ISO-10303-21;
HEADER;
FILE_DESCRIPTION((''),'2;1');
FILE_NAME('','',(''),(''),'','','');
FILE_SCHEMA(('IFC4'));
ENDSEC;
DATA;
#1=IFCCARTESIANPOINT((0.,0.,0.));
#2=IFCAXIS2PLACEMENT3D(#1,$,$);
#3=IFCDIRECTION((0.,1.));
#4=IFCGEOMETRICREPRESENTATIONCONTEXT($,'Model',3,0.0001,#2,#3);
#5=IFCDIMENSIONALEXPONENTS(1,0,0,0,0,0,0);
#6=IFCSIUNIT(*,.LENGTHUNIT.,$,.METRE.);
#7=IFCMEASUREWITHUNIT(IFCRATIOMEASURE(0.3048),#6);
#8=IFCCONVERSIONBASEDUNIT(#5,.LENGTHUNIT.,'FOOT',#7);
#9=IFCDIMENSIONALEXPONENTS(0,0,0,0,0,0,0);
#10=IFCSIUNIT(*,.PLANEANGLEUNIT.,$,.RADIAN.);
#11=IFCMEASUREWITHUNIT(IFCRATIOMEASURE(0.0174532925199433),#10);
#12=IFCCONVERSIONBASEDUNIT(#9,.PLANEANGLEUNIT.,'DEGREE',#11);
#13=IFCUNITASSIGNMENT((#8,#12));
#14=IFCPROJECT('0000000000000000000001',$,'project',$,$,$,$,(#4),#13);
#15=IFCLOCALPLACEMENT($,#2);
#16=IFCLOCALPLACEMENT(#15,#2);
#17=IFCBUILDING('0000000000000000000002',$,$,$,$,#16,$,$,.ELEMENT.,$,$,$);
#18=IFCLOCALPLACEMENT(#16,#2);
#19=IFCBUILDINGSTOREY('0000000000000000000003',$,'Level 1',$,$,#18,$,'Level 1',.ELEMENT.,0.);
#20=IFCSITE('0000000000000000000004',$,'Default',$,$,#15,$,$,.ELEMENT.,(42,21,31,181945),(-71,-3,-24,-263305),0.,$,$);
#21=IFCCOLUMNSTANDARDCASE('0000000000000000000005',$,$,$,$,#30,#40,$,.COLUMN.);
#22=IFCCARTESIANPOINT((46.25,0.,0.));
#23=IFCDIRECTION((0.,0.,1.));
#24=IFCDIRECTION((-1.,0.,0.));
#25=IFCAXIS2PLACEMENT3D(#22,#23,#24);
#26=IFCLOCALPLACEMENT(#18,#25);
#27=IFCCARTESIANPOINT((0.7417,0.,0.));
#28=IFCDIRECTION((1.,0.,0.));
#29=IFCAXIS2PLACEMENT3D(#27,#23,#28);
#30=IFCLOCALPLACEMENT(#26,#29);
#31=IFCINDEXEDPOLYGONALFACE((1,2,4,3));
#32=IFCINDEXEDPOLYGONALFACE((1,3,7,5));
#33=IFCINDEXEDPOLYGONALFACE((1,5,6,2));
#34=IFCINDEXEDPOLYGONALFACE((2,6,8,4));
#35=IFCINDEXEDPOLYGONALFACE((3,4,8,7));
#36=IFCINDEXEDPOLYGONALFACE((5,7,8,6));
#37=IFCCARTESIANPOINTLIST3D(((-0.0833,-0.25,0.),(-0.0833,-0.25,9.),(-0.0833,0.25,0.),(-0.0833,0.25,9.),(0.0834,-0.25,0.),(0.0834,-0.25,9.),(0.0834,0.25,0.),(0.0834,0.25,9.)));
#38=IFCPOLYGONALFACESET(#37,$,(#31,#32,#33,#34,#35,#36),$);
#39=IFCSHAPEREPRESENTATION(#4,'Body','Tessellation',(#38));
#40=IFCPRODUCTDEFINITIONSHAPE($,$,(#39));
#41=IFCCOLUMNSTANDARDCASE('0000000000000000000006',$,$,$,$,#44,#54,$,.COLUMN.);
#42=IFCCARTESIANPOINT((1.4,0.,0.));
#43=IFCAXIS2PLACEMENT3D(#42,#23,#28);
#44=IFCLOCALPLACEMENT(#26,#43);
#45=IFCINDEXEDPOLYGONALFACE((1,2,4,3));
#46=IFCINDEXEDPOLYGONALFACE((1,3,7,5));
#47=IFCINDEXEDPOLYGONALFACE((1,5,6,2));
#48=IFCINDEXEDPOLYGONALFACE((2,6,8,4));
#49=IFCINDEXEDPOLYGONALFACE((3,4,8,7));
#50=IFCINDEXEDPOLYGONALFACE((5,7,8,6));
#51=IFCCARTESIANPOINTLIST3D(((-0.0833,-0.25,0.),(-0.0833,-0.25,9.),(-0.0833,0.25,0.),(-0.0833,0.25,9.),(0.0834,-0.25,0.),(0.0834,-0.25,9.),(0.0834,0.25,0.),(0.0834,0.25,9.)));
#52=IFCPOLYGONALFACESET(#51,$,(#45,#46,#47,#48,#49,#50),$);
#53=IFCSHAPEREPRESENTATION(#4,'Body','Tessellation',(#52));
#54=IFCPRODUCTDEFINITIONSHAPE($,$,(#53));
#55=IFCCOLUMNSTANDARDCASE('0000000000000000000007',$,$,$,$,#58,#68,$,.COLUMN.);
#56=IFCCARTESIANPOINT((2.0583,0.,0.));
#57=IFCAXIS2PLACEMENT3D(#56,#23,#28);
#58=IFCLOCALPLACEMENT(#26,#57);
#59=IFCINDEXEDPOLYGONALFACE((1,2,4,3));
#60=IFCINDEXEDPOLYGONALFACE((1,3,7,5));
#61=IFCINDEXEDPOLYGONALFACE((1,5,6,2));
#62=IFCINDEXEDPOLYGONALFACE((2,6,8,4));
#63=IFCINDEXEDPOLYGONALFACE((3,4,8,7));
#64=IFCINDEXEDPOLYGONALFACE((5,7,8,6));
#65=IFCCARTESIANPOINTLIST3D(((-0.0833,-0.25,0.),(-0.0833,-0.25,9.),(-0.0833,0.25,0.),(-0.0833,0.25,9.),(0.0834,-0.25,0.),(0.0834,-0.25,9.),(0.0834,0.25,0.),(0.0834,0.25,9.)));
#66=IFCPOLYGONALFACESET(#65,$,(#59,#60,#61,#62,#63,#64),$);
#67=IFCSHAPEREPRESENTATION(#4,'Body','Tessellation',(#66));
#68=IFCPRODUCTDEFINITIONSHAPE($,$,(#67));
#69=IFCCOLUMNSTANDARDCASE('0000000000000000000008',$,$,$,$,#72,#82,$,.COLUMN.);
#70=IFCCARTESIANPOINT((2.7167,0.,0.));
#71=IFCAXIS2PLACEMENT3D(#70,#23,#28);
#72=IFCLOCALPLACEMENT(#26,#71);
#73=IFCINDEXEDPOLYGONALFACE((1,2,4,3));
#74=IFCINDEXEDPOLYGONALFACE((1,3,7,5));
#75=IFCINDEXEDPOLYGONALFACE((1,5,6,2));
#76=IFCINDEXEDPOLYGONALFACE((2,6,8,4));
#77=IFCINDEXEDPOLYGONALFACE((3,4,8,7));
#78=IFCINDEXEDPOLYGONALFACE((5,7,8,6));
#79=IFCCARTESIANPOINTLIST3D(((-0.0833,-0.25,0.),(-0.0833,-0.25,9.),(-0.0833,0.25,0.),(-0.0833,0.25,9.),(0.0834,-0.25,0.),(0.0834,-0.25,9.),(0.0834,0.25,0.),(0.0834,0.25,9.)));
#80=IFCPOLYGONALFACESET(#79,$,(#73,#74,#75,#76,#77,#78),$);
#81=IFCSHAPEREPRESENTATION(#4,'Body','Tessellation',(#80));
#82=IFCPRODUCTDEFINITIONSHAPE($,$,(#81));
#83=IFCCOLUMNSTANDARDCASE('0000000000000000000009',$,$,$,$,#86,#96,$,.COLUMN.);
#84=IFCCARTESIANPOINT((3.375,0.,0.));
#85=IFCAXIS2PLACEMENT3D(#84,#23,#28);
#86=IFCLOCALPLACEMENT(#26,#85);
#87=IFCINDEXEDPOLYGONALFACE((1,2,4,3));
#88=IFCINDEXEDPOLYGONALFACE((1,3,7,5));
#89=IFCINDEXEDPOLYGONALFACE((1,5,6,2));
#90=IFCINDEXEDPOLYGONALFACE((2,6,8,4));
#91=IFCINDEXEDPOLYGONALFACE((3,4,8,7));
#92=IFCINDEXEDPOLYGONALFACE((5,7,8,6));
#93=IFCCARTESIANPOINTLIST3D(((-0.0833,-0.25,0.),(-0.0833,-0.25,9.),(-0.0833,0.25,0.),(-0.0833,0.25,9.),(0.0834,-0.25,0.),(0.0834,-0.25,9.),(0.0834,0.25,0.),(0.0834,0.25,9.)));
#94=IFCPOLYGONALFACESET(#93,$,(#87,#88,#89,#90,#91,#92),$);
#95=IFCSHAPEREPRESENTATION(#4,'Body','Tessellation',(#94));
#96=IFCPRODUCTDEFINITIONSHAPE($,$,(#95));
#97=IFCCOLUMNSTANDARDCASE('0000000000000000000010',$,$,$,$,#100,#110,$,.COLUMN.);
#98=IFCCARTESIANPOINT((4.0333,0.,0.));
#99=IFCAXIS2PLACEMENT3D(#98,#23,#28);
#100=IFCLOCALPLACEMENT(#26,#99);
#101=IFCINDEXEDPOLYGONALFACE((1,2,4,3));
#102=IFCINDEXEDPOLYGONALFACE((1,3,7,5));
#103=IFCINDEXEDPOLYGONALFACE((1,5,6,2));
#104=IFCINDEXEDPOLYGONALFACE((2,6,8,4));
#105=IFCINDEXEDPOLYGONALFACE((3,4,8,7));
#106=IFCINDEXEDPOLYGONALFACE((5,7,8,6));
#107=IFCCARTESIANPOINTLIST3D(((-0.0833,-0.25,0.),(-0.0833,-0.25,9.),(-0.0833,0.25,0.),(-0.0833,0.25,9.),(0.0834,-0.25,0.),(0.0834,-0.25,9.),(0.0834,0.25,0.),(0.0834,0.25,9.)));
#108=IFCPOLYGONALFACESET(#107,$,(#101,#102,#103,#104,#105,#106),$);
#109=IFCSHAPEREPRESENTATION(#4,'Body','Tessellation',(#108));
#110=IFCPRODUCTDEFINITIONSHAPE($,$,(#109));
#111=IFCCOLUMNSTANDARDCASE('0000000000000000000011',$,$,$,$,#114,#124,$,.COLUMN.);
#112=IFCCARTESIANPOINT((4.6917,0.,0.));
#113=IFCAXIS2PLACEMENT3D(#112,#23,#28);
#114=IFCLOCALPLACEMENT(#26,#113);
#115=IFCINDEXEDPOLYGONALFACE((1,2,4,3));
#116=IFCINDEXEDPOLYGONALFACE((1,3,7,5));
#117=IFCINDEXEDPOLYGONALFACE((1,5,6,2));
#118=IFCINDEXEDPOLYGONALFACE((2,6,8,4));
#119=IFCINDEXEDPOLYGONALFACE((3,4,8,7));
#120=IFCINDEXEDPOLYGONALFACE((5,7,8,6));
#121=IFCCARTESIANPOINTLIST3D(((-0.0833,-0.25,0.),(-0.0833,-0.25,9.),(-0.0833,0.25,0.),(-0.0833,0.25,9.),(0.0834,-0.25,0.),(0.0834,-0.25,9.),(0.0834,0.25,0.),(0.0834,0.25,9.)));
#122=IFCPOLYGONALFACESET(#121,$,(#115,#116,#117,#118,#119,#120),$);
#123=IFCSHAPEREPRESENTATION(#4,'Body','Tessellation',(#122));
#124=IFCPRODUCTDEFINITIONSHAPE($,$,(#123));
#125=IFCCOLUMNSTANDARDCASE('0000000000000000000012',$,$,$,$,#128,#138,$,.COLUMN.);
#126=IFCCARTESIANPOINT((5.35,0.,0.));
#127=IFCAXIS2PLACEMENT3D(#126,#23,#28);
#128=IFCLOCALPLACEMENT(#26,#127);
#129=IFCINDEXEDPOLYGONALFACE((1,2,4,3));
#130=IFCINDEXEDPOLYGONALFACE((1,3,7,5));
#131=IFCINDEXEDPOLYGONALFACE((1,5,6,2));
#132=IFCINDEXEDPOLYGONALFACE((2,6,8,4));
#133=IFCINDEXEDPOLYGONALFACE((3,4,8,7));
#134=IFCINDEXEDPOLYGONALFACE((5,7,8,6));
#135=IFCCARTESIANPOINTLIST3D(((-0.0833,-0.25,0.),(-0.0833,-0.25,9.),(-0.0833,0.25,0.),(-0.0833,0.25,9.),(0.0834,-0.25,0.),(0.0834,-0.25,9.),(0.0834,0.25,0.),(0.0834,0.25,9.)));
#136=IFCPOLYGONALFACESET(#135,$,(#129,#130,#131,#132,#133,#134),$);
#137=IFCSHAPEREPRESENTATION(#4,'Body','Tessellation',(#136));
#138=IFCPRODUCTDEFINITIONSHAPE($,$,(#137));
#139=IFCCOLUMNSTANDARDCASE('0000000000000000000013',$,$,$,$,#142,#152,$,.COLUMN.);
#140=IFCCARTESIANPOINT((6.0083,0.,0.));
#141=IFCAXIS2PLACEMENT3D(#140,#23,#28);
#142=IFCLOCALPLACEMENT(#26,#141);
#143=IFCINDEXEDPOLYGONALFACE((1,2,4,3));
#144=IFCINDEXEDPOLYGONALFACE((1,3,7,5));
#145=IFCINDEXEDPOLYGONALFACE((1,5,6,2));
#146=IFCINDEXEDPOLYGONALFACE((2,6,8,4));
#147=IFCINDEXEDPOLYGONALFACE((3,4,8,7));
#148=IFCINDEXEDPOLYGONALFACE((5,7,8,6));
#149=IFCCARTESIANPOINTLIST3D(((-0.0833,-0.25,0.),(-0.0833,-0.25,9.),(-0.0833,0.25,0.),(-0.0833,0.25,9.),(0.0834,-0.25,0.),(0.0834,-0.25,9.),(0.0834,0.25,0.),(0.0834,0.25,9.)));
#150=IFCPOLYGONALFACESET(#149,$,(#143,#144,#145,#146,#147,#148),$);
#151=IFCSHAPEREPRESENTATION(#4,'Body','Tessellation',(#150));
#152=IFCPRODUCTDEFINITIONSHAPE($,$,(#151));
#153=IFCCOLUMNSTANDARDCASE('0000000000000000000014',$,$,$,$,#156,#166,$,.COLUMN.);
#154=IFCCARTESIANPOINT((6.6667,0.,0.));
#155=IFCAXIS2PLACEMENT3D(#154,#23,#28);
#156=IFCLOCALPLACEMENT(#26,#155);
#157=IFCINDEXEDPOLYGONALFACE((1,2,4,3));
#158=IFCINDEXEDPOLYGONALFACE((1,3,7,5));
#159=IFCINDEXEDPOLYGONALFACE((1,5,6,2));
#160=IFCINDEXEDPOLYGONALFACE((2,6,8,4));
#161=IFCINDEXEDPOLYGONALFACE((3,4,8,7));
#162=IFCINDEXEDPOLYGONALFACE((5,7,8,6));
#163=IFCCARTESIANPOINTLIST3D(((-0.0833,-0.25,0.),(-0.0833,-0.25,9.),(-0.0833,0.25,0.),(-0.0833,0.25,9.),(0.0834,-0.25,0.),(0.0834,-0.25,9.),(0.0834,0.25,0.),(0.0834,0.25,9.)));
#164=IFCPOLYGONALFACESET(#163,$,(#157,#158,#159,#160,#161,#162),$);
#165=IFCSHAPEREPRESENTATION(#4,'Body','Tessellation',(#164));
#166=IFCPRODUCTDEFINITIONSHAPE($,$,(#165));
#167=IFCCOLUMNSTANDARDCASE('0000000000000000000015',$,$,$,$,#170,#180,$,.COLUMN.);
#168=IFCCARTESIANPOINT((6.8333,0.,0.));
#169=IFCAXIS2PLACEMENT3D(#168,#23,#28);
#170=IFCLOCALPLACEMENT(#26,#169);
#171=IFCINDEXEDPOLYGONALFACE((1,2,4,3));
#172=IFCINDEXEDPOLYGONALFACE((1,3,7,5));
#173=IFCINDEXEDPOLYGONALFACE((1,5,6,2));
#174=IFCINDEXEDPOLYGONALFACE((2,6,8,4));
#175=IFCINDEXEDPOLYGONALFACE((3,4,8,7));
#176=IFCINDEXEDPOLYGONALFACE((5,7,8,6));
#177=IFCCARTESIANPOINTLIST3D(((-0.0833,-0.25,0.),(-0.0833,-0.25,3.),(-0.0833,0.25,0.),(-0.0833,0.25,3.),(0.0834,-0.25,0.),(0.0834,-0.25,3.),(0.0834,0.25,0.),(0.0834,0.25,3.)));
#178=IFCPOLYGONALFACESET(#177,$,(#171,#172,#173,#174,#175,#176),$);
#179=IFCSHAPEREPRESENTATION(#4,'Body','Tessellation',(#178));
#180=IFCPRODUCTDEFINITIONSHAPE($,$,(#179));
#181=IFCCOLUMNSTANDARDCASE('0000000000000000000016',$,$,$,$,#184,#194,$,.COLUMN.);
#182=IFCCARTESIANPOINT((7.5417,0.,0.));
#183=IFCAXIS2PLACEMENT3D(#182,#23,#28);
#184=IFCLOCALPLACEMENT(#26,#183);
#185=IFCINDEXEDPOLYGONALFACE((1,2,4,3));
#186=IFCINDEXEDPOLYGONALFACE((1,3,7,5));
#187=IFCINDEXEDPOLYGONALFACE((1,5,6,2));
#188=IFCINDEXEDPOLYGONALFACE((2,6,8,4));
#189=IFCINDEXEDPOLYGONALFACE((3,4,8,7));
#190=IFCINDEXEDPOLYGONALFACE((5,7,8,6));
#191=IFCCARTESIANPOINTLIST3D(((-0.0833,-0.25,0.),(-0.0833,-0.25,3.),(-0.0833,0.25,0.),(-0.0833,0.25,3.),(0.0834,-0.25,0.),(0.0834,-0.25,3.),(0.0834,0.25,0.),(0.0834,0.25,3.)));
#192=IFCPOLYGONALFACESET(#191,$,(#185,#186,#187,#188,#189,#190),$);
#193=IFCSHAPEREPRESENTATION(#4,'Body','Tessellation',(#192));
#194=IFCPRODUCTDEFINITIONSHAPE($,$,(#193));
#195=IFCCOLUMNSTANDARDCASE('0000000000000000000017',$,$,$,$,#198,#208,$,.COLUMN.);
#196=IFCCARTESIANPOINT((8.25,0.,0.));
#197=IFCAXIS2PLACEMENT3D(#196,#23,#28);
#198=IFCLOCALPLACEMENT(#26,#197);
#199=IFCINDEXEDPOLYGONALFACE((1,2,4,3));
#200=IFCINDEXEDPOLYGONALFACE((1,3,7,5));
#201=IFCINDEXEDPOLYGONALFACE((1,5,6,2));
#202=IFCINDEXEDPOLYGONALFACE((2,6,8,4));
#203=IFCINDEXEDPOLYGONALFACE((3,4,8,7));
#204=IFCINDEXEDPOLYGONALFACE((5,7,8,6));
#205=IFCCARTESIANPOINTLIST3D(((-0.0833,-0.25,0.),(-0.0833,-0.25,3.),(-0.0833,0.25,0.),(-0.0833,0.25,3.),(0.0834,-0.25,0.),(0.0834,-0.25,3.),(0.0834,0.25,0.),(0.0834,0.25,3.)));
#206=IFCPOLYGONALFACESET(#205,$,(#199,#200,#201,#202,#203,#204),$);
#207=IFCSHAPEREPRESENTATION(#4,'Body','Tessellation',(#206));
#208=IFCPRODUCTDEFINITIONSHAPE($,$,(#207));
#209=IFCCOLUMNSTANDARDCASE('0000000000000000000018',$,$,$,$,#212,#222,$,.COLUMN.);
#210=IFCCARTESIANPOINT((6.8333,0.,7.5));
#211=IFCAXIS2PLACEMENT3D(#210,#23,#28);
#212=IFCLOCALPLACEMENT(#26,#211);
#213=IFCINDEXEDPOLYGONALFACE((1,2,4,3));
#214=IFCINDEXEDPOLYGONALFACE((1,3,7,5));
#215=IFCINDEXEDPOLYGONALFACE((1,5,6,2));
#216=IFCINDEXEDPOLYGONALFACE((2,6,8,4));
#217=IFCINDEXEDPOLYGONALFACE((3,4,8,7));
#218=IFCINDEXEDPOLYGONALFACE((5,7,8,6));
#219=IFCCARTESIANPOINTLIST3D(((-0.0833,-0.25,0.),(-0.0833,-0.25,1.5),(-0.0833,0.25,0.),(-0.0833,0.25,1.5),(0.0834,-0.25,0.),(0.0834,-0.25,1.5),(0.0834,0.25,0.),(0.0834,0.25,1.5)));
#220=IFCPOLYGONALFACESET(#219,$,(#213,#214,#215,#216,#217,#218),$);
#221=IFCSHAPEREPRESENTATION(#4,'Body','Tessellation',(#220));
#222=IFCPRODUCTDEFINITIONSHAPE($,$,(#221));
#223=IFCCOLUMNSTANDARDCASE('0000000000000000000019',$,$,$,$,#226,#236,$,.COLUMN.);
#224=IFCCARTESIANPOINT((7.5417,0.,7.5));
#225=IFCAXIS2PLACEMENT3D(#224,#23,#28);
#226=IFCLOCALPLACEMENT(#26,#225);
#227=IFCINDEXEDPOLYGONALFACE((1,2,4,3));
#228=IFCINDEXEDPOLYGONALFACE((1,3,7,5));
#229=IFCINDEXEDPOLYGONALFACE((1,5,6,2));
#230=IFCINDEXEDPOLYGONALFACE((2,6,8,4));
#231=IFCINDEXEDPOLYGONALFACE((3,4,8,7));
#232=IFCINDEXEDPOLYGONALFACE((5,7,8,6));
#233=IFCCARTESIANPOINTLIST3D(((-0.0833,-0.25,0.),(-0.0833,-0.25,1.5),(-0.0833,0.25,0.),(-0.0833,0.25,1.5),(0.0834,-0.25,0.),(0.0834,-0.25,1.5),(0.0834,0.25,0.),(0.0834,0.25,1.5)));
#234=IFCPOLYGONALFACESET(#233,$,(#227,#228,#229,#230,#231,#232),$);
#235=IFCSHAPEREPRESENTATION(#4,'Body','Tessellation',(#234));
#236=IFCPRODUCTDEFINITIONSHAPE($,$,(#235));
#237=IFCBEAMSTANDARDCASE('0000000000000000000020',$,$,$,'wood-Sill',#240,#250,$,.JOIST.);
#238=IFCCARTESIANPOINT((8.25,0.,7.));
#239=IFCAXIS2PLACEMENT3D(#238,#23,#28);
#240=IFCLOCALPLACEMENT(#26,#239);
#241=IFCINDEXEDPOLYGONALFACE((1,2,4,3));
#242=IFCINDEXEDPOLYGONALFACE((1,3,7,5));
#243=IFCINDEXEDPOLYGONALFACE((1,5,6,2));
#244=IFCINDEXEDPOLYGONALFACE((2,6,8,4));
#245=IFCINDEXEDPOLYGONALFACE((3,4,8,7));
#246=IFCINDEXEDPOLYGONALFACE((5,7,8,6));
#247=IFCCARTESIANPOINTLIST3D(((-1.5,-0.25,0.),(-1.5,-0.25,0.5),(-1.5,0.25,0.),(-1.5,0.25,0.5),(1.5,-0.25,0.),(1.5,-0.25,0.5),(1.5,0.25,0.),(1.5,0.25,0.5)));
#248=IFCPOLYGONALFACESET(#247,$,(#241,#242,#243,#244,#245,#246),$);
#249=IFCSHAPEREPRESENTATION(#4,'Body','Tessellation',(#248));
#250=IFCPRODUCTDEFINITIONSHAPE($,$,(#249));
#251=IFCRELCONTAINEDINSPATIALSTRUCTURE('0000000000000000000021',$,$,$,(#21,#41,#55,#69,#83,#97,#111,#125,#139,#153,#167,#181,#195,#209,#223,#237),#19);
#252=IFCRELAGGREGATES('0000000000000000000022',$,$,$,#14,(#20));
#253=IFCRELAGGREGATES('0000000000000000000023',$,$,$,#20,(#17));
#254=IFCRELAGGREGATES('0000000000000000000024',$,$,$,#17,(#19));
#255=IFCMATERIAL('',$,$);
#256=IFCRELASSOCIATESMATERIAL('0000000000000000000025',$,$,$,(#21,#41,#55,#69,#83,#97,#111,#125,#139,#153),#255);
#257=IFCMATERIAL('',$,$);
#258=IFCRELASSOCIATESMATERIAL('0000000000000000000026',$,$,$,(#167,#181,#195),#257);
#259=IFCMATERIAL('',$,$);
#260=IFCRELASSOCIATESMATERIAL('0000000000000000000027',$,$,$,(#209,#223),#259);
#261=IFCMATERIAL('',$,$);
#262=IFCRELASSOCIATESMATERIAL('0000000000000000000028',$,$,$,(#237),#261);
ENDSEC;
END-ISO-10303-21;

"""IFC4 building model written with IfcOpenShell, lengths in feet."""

from ifc_helpers import new_model, entity, si_unit, converted_unit, direction, frame, origin, place, context, project, spatial, rectangle, extrude, material, element, save


model = new_model("IFC4")

# Units and contexts
model_context = context("Model", 3, precision=0.0001, world=origin(), true_north=direction((0.0, 1.0)))
ifc_project = project(units=[converted_unit("LENGTHUNIT", "FOOT", entity("IfcRatioMeasure", 0.3048), si_unit("LENGTHUNIT", "METRE"), dimensions=[1, 0, 0, 0, 0, 0, 0]), converted_unit("PLANEANGLEUNIT", "DEGREE", entity("IfcRatioMeasure", 0.0174532925199433), si_unit("PLANEANGLEUNIT", "RADIAN"), dimensions=[0, 0, 0, 0, 0, 0, 0])], contexts=[model_context])

# Site, building, storey
site_placement = place(None, origin())
site = spatial("IfcSite", under=ifc_project, at=site_placement, Name="Default", CompositionType="ELEMENT", RefLatitude=(42, 21, 31, 181945), RefLongitude=(-71, -3, -24, -263305), RefElevation=0.0)
building_placement = place(site_placement, origin())
building = spatial("IfcBuilding", under=site, at=building_placement, CompositionType="ELEMENT")
storey_placement = place(building_placement, origin())
storey = spatial("IfcBuildingStorey", under=building, at=storey_placement, Name="Level 1", LongName="Level 1", CompositionType="ELEMENT", Elevation=0.0)

# Columns
ifc_material_1 = material(Name="")
placement_1 = place(storey_placement, frame((46.25, 0.0, 0.0), z_axis=(0.0, 0.0, 1.0), x_axis=(-1.0, 0.0, 0.0)))
for number, where, z_axis, x_axis in (
    (1, (0.7417, 0.0, 0.0), (0.0, 0.0, 1.0), (1.0, 0.0, 0.0)),
    (2, (1.4, 0.0, 0.0), (0.0, 0.0, 1.0), (1.0, 0.0, 0.0)),
    (3, (2.0583, 0.0, 0.0), (0.0, 0.0, 1.0), (1.0, 0.0, 0.0)),
    (4, (2.7167, 0.0, 0.0), (0.0, 0.0, 1.0), (1.0, 0.0, 0.0)),
    (5, (3.375, 0.0, 0.0), (0.0, 0.0, 1.0), (1.0, 0.0, 0.0)),
    (6, (4.0333, 0.0, 0.0), (0.0, 0.0, 1.0), (1.0, 0.0, 0.0)),
    (7, (4.6917, 0.0, 0.0), (0.0, 0.0, 1.0), (1.0, 0.0, 0.0)),
    (8, (5.35, 0.0, 0.0), (0.0, 0.0, 1.0), (1.0, 0.0, 0.0)),
    (9, (6.0083, 0.0, 0.0), (0.0, 0.0, 1.0), (1.0, 0.0, 0.0)),
    (10, (6.6667, 0.0, 0.0), (0.0, 0.0, 1.0), (1.0, 0.0, 0.0)),
):
    element("IfcColumnStandardCase", number, at=place(placement_1, frame(where, z_axis=z_axis, x_axis=x_axis)), inside=storey, material=ifc_material_1, PredefinedType="COLUMN", context=model_context, shape_type="SweptSolid", body=[
        extrude(rectangle(XDim=0.1667, YDim=0.5), origin(), (0.0, 0.0, 1.0), 9.0),
    ])
ifc_material_2 = material(Name="")
for number, where, z_axis, x_axis in (
    (11, (6.8333, 0.0, 0.0), (0.0, 0.0, 1.0), (1.0, 0.0, 0.0)),
    (12, (7.5417, 0.0, 0.0), (0.0, 0.0, 1.0), (1.0, 0.0, 0.0)),
    (13, (8.25, 0.0, 0.0), (0.0, 0.0, 1.0), (1.0, 0.0, 0.0)),
):
    element("IfcColumnStandardCase", number, at=place(placement_1, frame(where, z_axis=z_axis, x_axis=x_axis)), inside=storey, material=ifc_material_2, PredefinedType="COLUMN", context=model_context, shape_type="SweptSolid", body=[
        extrude(rectangle(XDim=0.1667, YDim=0.5), origin(), (0.0, 0.0, 1.0), 3.0),
    ])
ifc_material_3 = material(Name="")
for number, where, z_axis, x_axis in (
    (14, (6.8333, 0.0, 7.5), (0.0, 0.0, 1.0), (1.0, 0.0, 0.0)),
    (15, (7.5417, 0.0, 7.5), (0.0, 0.0, 1.0), (1.0, 0.0, 0.0)),
):
    element("IfcColumnStandardCase", number, at=place(placement_1, frame(where, z_axis=z_axis, x_axis=x_axis)), inside=storey, material=ifc_material_3, PredefinedType="COLUMN", context=model_context, shape_type="SweptSolid", body=[
        extrude(rectangle(XDim=0.1667, YDim=0.5), origin(), (0.0, 0.0, 1.0), 1.5),
    ])

# Beam
ifc_material_4 = material(Name="")
for number, where, z_axis, x_axis in (
    (16, (8.25, 0.0, 7.0), (0.0, 0.0, 1.0), (1.0, 0.0, 0.0)),
):
    element("IfcBeamStandardCase", number, at=place(placement_1, frame(where, z_axis=z_axis, x_axis=x_axis)), inside=storey, material=ifc_material_4, ObjectType="wood-Sill", PredefinedType="JOIST", context=model_context, shape_type="SweptSolid", body=[
        extrude(rectangle(XDim=3.0, YDim=0.5), origin(), (0.0, 0.0, 1.0), 0.5),
    ])

save(model, "model.ifc")
